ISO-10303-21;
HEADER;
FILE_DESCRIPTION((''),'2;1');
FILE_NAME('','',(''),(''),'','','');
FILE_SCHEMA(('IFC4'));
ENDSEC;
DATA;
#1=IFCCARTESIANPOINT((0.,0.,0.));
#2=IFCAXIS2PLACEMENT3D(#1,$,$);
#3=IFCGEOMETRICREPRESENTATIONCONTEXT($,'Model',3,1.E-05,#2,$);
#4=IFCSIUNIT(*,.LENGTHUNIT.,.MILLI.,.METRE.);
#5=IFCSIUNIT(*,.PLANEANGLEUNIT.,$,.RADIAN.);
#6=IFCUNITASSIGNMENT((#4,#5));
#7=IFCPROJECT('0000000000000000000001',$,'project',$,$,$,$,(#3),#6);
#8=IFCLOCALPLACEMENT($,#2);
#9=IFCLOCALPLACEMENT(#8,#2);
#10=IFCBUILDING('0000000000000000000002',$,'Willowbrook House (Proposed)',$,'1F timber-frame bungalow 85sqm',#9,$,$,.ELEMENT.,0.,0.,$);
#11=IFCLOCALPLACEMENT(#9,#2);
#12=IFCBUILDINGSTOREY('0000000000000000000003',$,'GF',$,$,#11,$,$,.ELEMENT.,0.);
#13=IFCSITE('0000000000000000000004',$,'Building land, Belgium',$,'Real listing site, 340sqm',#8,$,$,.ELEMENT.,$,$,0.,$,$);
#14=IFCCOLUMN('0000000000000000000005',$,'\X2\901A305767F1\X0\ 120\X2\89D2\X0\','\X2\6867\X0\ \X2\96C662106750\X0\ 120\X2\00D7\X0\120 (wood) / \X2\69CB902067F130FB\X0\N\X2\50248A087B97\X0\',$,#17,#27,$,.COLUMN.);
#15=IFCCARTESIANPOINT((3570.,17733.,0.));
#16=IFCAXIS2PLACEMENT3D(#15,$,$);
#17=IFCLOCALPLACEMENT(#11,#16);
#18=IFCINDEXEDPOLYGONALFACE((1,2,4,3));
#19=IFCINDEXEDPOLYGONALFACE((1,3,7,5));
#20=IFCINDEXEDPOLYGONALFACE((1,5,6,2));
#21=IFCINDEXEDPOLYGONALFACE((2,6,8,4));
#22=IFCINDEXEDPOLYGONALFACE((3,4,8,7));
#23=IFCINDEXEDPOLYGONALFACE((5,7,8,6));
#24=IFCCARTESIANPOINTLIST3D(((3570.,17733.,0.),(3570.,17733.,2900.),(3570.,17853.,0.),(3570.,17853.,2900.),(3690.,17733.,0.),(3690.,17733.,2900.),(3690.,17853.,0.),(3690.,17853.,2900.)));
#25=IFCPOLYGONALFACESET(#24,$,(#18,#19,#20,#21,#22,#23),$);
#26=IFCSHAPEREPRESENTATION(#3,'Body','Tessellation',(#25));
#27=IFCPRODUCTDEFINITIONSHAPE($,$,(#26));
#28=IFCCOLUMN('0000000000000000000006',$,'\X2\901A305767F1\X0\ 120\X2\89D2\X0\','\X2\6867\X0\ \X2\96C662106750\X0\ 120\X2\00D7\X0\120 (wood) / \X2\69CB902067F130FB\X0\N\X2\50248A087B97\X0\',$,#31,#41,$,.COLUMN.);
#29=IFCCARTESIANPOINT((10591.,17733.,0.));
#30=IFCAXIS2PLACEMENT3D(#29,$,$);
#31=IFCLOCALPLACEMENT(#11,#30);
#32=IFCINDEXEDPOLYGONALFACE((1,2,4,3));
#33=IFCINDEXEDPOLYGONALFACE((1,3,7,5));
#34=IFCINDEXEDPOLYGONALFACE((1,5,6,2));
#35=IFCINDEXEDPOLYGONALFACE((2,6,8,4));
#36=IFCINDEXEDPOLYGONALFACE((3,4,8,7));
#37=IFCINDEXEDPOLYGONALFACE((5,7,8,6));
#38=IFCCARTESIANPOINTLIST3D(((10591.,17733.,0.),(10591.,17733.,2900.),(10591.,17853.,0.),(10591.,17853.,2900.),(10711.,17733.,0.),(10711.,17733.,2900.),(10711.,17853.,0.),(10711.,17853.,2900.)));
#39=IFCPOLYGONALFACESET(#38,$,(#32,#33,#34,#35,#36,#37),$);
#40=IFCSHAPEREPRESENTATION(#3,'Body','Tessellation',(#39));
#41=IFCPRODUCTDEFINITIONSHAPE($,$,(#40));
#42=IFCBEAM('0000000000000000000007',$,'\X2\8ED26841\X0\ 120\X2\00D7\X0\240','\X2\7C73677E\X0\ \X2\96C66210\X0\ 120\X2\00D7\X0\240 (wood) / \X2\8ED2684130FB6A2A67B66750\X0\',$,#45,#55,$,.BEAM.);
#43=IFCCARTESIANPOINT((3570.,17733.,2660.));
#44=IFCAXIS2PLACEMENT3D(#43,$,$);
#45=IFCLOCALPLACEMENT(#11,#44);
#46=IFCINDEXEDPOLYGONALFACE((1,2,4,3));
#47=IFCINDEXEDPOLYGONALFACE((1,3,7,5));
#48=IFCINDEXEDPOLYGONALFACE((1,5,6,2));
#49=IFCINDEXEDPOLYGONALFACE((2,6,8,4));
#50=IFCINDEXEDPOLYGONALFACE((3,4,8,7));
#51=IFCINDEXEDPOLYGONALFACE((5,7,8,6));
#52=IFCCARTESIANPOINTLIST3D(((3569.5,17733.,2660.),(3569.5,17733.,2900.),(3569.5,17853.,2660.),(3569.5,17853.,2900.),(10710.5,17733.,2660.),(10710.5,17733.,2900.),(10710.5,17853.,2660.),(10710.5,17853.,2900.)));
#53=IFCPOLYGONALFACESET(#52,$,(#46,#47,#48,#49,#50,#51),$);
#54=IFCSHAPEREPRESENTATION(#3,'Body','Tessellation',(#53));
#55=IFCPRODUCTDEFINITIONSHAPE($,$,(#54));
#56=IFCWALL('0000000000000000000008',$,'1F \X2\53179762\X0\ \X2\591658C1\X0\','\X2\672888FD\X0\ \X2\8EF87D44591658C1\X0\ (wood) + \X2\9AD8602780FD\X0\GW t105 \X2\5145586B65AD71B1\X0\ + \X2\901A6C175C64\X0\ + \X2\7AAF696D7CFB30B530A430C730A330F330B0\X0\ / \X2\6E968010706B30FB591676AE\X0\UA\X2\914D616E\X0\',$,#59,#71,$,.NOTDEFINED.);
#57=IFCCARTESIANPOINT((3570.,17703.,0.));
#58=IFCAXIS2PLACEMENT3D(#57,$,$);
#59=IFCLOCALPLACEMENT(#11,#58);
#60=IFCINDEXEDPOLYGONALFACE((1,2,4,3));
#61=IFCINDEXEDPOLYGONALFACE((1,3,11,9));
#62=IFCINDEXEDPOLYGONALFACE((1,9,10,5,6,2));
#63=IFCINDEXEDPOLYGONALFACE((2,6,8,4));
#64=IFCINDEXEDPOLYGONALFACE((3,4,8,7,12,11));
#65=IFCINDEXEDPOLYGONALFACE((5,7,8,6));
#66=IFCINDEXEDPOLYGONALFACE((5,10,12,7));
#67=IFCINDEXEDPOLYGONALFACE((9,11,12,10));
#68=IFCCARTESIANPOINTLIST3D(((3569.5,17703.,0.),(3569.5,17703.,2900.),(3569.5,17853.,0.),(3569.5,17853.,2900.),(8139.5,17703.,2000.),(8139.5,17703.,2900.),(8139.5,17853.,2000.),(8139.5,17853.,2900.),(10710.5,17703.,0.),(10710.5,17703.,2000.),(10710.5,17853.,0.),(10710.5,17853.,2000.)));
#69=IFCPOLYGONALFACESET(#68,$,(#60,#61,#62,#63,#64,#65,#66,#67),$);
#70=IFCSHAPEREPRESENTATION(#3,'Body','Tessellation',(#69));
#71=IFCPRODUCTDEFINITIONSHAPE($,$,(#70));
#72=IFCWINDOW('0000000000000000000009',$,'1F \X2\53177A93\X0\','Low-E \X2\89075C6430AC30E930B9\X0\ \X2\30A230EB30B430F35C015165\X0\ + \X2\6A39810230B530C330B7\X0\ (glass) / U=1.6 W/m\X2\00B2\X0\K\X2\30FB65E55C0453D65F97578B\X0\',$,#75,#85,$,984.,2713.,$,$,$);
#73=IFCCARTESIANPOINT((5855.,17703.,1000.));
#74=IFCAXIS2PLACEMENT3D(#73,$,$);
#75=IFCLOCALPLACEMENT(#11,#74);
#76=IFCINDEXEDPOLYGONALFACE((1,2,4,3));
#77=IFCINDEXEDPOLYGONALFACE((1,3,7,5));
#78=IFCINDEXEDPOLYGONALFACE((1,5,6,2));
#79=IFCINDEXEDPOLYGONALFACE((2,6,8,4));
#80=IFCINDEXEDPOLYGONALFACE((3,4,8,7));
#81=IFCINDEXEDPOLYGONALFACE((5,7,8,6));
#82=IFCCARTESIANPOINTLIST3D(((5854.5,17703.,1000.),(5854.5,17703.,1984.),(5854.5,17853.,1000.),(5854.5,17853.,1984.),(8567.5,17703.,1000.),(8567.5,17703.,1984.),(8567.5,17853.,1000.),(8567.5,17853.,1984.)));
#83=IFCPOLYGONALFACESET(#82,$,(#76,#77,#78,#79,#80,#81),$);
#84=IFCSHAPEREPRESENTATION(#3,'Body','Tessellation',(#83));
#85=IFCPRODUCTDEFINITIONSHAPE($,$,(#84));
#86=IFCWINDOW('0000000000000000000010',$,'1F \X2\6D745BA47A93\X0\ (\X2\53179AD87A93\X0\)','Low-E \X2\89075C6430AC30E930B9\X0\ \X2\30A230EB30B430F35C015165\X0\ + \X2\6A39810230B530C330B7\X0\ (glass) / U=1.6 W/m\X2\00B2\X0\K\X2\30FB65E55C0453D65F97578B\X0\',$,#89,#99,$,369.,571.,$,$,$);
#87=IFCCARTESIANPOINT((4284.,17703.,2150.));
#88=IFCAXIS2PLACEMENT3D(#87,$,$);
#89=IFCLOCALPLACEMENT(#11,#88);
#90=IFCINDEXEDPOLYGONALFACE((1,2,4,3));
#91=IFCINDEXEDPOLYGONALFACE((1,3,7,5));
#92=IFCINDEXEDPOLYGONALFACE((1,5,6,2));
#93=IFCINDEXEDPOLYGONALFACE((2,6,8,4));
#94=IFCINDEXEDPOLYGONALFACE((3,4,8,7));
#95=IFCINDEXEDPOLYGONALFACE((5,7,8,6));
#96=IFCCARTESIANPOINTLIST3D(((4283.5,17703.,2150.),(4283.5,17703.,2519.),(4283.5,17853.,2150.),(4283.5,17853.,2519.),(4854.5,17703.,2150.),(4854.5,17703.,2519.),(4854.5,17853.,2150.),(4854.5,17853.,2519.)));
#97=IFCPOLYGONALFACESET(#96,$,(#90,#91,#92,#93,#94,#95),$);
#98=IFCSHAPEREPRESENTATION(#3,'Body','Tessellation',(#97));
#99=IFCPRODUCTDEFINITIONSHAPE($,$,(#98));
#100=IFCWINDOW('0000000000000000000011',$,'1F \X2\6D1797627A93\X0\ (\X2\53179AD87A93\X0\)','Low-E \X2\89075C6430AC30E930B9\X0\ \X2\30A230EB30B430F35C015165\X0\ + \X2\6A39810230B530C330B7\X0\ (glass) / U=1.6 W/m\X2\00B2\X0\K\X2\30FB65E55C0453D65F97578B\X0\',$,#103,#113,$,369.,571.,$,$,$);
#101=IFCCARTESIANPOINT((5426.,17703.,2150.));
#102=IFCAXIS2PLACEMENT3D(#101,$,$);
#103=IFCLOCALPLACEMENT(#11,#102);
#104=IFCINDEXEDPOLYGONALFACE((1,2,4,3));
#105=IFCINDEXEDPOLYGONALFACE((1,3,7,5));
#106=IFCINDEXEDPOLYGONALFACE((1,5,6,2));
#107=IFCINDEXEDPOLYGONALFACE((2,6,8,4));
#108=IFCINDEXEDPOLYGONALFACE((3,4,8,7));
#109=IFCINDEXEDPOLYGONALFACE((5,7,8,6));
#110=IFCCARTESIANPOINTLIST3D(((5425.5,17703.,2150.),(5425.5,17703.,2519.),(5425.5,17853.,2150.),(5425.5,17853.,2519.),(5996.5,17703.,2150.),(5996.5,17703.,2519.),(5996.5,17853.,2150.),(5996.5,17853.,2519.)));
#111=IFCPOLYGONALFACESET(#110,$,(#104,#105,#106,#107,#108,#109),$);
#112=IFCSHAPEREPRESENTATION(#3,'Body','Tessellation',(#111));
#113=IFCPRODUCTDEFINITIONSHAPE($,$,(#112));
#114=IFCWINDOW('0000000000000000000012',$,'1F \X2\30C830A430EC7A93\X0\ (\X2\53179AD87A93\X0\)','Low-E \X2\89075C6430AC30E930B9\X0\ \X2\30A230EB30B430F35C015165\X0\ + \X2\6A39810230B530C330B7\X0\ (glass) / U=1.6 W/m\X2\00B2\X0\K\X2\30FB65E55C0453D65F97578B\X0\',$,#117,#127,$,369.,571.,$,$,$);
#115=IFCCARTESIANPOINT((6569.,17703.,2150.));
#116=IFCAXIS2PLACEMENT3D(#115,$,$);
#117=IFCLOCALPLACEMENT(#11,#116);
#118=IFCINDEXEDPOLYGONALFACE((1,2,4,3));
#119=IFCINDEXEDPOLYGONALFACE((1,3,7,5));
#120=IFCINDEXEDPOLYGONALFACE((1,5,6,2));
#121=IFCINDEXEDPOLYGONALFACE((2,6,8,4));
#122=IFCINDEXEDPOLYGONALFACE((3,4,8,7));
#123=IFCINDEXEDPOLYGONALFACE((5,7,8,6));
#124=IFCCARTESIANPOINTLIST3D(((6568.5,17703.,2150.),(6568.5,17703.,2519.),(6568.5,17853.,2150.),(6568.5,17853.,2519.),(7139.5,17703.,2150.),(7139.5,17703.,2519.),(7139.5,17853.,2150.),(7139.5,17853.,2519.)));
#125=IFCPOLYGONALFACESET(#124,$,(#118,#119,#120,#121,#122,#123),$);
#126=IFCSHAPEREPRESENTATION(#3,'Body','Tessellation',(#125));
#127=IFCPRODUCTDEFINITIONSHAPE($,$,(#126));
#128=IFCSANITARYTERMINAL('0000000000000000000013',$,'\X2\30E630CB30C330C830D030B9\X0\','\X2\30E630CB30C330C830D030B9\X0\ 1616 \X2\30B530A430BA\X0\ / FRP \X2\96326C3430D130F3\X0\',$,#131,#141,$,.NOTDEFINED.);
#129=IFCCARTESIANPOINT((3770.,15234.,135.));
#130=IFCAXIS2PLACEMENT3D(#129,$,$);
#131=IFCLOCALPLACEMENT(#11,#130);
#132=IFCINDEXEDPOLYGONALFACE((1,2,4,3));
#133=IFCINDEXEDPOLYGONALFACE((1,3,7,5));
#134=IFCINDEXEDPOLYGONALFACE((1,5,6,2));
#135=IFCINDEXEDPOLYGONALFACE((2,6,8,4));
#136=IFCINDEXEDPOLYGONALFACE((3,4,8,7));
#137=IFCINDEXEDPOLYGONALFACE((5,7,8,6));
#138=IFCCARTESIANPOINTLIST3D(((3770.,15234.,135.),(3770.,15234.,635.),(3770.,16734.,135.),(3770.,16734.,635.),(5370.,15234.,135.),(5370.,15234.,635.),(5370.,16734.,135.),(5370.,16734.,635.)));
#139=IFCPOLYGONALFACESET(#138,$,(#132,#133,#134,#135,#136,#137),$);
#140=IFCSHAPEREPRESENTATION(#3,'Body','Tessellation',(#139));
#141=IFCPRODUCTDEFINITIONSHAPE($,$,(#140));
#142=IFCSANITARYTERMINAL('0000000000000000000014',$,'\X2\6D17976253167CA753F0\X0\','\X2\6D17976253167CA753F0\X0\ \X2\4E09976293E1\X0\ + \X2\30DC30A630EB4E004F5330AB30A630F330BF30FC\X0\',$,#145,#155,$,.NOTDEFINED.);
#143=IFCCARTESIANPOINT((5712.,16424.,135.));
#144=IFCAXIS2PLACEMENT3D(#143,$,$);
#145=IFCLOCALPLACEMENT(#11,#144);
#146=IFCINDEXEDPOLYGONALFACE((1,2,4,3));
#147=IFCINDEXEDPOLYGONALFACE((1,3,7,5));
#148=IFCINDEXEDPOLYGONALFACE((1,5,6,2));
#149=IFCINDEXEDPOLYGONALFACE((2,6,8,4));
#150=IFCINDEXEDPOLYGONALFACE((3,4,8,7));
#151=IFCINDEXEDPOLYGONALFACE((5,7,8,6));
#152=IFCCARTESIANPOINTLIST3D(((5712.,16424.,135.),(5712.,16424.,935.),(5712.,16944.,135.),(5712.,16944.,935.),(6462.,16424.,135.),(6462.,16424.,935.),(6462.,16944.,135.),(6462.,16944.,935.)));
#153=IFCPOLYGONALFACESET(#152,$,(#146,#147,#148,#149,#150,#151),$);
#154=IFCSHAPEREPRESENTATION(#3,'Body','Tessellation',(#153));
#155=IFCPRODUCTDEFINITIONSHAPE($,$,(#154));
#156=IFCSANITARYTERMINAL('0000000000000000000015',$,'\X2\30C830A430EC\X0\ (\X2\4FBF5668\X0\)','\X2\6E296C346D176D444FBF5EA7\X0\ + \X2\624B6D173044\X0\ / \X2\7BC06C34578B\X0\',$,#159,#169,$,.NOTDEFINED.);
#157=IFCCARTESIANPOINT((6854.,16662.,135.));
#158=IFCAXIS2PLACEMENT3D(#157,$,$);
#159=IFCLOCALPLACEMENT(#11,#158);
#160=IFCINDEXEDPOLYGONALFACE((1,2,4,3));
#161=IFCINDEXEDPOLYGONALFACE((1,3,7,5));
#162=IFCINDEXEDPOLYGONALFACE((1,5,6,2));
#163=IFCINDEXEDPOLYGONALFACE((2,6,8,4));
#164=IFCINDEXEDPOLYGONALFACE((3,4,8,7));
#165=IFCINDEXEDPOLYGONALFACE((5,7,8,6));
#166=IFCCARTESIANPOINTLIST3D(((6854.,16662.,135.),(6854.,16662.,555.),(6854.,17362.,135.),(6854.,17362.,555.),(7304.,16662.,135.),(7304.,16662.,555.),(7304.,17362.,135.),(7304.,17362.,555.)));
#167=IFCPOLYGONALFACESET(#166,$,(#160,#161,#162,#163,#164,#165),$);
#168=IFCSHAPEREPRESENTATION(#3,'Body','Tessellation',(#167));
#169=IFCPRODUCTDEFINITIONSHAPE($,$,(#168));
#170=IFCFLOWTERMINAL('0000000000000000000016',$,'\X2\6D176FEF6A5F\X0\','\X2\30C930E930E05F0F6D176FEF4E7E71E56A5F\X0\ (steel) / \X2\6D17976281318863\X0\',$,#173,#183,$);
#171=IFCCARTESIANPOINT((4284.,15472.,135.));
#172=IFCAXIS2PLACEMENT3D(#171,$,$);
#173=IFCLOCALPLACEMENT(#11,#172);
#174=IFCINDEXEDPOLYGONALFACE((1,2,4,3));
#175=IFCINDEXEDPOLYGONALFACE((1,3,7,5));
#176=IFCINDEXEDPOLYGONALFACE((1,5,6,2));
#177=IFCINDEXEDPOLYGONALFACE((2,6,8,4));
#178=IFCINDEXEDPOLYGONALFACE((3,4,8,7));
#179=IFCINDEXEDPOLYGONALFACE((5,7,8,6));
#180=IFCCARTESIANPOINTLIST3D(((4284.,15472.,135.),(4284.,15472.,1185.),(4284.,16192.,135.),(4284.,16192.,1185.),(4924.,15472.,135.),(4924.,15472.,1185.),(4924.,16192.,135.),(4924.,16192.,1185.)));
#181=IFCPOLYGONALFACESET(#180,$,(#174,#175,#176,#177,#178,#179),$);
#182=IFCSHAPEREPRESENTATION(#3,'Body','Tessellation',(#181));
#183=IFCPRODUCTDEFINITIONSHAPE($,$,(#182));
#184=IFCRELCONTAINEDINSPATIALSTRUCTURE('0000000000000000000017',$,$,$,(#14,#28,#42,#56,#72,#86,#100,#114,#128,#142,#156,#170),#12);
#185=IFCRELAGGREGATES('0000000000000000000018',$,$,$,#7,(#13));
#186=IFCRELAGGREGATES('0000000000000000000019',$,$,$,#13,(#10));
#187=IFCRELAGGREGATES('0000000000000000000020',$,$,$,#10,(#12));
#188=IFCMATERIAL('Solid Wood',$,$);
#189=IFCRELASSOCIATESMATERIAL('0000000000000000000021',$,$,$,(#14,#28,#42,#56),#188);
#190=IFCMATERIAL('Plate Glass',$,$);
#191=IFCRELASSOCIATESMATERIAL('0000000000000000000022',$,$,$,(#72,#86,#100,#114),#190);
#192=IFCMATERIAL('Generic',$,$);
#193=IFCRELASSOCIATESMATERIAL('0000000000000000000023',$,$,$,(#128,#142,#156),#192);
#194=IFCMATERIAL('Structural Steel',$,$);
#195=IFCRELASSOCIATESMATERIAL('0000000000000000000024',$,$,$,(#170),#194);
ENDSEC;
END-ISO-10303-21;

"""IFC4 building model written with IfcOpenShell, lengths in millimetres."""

from ifc_helpers import new_model, si_unit, frame, frame_2d, origin, place, context, project, spatial, rectangle, extrude, material, element, fill, save


model = new_model("IFC4")

# Units and contexts
model_context = context("Model", 3, precision=1e-05, world=origin())
ifc_project = project(units=[si_unit("LENGTHUNIT", "METRE", prefix="MILLI"), si_unit("PLANEANGLEUNIT", "RADIAN")], contexts=[model_context])

# Site, building, storey
site_placement = place(None, origin())
site = spatial("IfcSite", under=ifc_project, at=site_placement, Name="Building land, Belgium", ObjectType="Real listing site, 340sqm", CompositionType="ELEMENT", RefElevation=0.0)
building_placement = place(site_placement, origin())
building = spatial("IfcBuilding", under=site, at=building_placement, Name="Willowbrook House (Proposed)", ObjectType="1F timber-frame bungalow 85sqm", CompositionType="ELEMENT", ElevationOfRefHeight=0.0, ElevationOfTerrain=0.0)
storey_placement = place(building_placement, origin())
storey = spatial("IfcBuildingStorey", under=building, at=storey_placement, Name="GF", CompositionType="ELEMENT", Elevation=0.0)

# Columns
ifc_material_1 = material(Name="Solid Wood")
column_1_placement = place(storey_placement, frame((3570.0, 17733.0, 0.0)))
element("IfcColumn", 1, at=column_1_placement, inside=storey, material=ifc_material_1, Name="通し柱 120角", Description="桧 集成材 120×120 (wood) / 構造柱・N値計算", PredefinedType="COLUMN", context=model_context, shape_type="SweptSolid", body=[
    extrude(rectangle(XDim=120.0, YDim=120.0, at=frame_2d((60.0, 60.0))), frame((3570.0, 17733.0, 0.0)), (0.0, 0.0, 1.0), 2900.0),
])
column_2_placement = place(storey_placement, frame((10591.0, 17733.0, 0.0)))
element("IfcColumn", 2, at=column_2_placement, inside=storey, material=ifc_material_1, Name="通し柱 120角", Description="桧 集成材 120×120 (wood) / 構造柱・N値計算", PredefinedType="COLUMN", context=model_context, shape_type="SweptSolid", body=[
    extrude(rectangle(XDim=120.0, YDim=120.0, at=frame_2d((60.0, 60.0))), frame((10591.0, 17733.0, 0.0)), (0.0, 0.0, 1.0), 2900.0),
])

# Beam
beam_1_placement = place(storey_placement, frame((3570.0, 17733.0, 2660.0)))
element("IfcBeam", 3, at=beam_1_placement, inside=storey, material=ifc_material_1, Name="軒桁 120×240", Description="米松 集成 120×240 (wood) / 軒桁・横架材", PredefinedType="BEAM", context=model_context, shape_type="SweptSolid", body=[
    extrude(rectangle(XDim=7141.0, YDim=120.0, at=frame_2d((3570.0, 60.0))), frame((3570.0, 17733.0, 2660.0)), (0.0, 0.0, 1.0), 240.0),
])

# Wall, openings, windows
wall_placement = place(storey_placement, frame((3570.0, 17703.0, 0.0)))
wall = element("IfcWall", 4, at=wall_placement, inside=storey, material=ifc_material_1, Name="1F 北面 外壁", Description="木製 軸組外壁 (wood) + 高性能GW t105 充填断熱 + 通気層 + 窯業系サイディング / 準耐火・外皮UA配慮", PredefinedType="NOTDEFINED", context=model_context, shape_type="SweptSolid", body=[
    extrude(rectangle(XDim=7141.0, YDim=150.0, at=frame_2d((3570.0, 75.0))), frame((3570.0, 17703.0, 0.0)), (0.0, 0.0, 1.0), 2900.0),
])
opening_1_placement = place(storey_placement, frame((5855.0, 17703.0, 1000.0)))
opening_1 = element("IfcOpeningElement", 5, at=opening_1_placement, cuts=wall, PredefinedType="NOTDEFINED", context=model_context, shape_type="SweptSolid", body=[
    extrude(rectangle(XDim=2713.0, YDim=150.0, at=frame_2d((1356.0, 75.0))), frame((5855.0, 17703.0, 1000.0)), (0.0, 0.0, 1.0), 984.0),
])
opening_2_placement = place(storey_placement, frame((4284.0, 17703.0, 2150.0)))
opening_2 = element("IfcOpeningElement", 6, at=opening_2_placement, cuts=wall, PredefinedType="NOTDEFINED", context=model_context, shape_type="SweptSolid", body=[
    extrude(rectangle(XDim=571.0, YDim=150.0, at=frame_2d((285.0, 75.0))), frame((4284.0, 17703.0, 2150.0)), (0.0, 0.0, 1.0), 369.0),
])
opening_3_placement = place(storey_placement, frame((5426.0, 17703.0, 2150.0)))
opening_3 = element("IfcOpeningElement", 7, at=opening_3_placement, cuts=wall, PredefinedType="NOTDEFINED", context=model_context, shape_type="SweptSolid", body=[
    extrude(rectangle(XDim=571.0, YDim=150.0, at=frame_2d((285.0, 75.0))), frame((5426.0, 17703.0, 2150.0)), (0.0, 0.0, 1.0), 369.0),
])
opening_4_placement = place(storey_placement, frame((6569.0, 17703.0, 2150.0)))
opening_4 = element("IfcOpeningElement", 8, at=opening_4_placement, cuts=wall, PredefinedType="NOTDEFINED", context=model_context, shape_type="SweptSolid", body=[
    extrude(rectangle(XDim=571.0, YDim=150.0, at=frame_2d((285.0, 75.0))), frame((6569.0, 17703.0, 2150.0)), (0.0, 0.0, 1.0), 369.0),
])
ifc_material_2 = material(Name="Plate Glass")
window_1_placement = place(storey_placement, frame((5855.0, 17703.0, 1000.0)))
window_1 = element("IfcWindow", 9, at=window_1_placement, inside=storey, material=ifc_material_2, Name="1F 北窓", Description="Low-E 複層ガラス アルゴン封入 + 樹脂サッシ (glass) / U=1.6 W/m²K・日射取得型", OverallHeight=984.0, OverallWidth=2713.0, context=model_context, shape_type="SweptSolid", body=[
    extrude(rectangle(XDim=2713.0, YDim=150.0, at=frame_2d((1356.0, 75.0))), frame((5855.0, 17703.0, 1000.0)), (0.0, 0.0, 1.0), 984.0),
])
fill(opening_1, window_1)
window_2_placement = place(storey_placement, frame((4284.0, 17703.0, 2150.0)))
window_2 = element("IfcWindow", 10, at=window_2_placement, inside=storey, material=ifc_material_2, Name="1F 浴室窓 (北高窓)", Description="Low-E 複層ガラス アルゴン封入 + 樹脂サッシ (glass) / U=1.6 W/m²K・日射取得型", OverallHeight=369.0, OverallWidth=571.0, context=model_context, shape_type="SweptSolid", body=[
    extrude(rectangle(XDim=571.0, YDim=150.0, at=frame_2d((285.0, 75.0))), frame((4284.0, 17703.0, 2150.0)), (0.0, 0.0, 1.0), 369.0),
])
fill(opening_2, window_2)
window_3_placement = place(storey_placement, frame((5426.0, 17703.0, 2150.0)))
window_3 = element("IfcWindow", 11, at=window_3_placement, inside=storey, material=ifc_material_2, Name="1F 洗面窓 (北高窓)", Description="Low-E 複層ガラス アルゴン封入 + 樹脂サッシ (glass) / U=1.6 W/m²K・日射取得型", OverallHeight=369.0, OverallWidth=571.0, context=model_context, shape_type="SweptSolid", body=[
    extrude(rectangle(XDim=571.0, YDim=150.0, at=frame_2d((285.0, 75.0))), frame((5426.0, 17703.0, 2150.0)), (0.0, 0.0, 1.0), 369.0),
])
fill(opening_3, window_3)
window_4_placement = place(storey_placement, frame((6569.0, 17703.0, 2150.0)))
window_4 = element("IfcWindow", 12, at=window_4_placement, inside=storey, material=ifc_material_2, Name="1F トイレ窓 (北高窓)", Description="Low-E 複層ガラス アルゴン封入 + 樹脂サッシ (glass) / U=1.6 W/m²K・日射取得型", OverallHeight=369.0, OverallWidth=571.0, context=model_context, shape_type="SweptSolid", body=[
    extrude(rectangle(XDim=571.0, YDim=150.0, at=frame_2d((285.0, 75.0))), frame((6569.0, 17703.0, 2150.0)), (0.0, 0.0, 1.0), 369.0),
])
fill(opening_4, window_4)

# Sanitary terminals
ifc_material_3 = material(Name="Generic")
sanitary_terminal_1_placement = place(storey_placement, frame((3770.0, 15234.0, 135.0)))
element("IfcSanitaryTerminal", 13, at=sanitary_terminal_1_placement, inside=storey, material=ifc_material_3, Name="ユニットバス", Description="ユニットバス 1616 サイズ / FRP 防水パン", PredefinedType="NOTDEFINED", context=model_context, shape_type="SweptSolid", body=[
    extrude(rectangle(XDim=1600.0, YDim=1500.0, at=frame_2d((800.0, 750.0))), frame((3770.0, 15234.0, 135.0)), (0.0, 0.0, 1.0), 500.0),
])
sanitary_terminal_2_placement = place(storey_placement, frame((5712.0, 16424.0, 135.0)))
element("IfcSanitaryTerminal", 14, at=sanitary_terminal_2_placement, inside=storey, material=ifc_material_3, Name="洗面化粧台", Description="洗面化粧台 三面鏡 + ボウル一体カウンター", PredefinedType="NOTDEFINED", context=model_context, shape_type="SweptSolid", body=[
    extrude(rectangle(XDim=750.0, YDim=520.0, at=frame_2d((375.0, 260.0))), frame((5712.0, 16424.0, 135.0)), (0.0, 0.0, 1.0), 800.0),
])
sanitary_terminal_3_placement = place(storey_placement, frame((6854.0, 16662.0, 135.0)))
element("IfcSanitaryTerminal", 15, at=sanitary_terminal_3_placement, inside=storey, material=ifc_material_3, Name="トイレ (便器)", Description="温水洗浄便座 + 手洗い / 節水型", PredefinedType="NOTDEFINED", context=model_context, shape_type="SweptSolid", body=[
    extrude(rectangle(XDim=450.0, YDim=700.0, at=frame_2d((225.0, 350.0))), frame((6854.0, 16662.0, 135.0)), (0.0, 0.0, 1.0), 420.0),
])

# Flow terminal
ifc_material_4 = material(Name="Structural Steel")
flow_terminal_placement = place(storey_placement, frame((4284.0, 15472.0, 135.0)))
element("IfcFlowTerminal", 16, at=flow_terminal_placement, inside=storey, material=ifc_material_4, Name="洗濯機", Description="ドラム式洗濯乾燥機 (steel) / 洗面脱衣", context=model_context, shape_type="SweptSolid", body=[
    extrude(rectangle(XDim=640.0, YDim=720.0, at=frame_2d((320.0, 360.0))), frame((4284.0, 15472.0, 135.0)), (0.0, 0.0, 1.0), 1050.0),
])

save(model, "model.ifc")
